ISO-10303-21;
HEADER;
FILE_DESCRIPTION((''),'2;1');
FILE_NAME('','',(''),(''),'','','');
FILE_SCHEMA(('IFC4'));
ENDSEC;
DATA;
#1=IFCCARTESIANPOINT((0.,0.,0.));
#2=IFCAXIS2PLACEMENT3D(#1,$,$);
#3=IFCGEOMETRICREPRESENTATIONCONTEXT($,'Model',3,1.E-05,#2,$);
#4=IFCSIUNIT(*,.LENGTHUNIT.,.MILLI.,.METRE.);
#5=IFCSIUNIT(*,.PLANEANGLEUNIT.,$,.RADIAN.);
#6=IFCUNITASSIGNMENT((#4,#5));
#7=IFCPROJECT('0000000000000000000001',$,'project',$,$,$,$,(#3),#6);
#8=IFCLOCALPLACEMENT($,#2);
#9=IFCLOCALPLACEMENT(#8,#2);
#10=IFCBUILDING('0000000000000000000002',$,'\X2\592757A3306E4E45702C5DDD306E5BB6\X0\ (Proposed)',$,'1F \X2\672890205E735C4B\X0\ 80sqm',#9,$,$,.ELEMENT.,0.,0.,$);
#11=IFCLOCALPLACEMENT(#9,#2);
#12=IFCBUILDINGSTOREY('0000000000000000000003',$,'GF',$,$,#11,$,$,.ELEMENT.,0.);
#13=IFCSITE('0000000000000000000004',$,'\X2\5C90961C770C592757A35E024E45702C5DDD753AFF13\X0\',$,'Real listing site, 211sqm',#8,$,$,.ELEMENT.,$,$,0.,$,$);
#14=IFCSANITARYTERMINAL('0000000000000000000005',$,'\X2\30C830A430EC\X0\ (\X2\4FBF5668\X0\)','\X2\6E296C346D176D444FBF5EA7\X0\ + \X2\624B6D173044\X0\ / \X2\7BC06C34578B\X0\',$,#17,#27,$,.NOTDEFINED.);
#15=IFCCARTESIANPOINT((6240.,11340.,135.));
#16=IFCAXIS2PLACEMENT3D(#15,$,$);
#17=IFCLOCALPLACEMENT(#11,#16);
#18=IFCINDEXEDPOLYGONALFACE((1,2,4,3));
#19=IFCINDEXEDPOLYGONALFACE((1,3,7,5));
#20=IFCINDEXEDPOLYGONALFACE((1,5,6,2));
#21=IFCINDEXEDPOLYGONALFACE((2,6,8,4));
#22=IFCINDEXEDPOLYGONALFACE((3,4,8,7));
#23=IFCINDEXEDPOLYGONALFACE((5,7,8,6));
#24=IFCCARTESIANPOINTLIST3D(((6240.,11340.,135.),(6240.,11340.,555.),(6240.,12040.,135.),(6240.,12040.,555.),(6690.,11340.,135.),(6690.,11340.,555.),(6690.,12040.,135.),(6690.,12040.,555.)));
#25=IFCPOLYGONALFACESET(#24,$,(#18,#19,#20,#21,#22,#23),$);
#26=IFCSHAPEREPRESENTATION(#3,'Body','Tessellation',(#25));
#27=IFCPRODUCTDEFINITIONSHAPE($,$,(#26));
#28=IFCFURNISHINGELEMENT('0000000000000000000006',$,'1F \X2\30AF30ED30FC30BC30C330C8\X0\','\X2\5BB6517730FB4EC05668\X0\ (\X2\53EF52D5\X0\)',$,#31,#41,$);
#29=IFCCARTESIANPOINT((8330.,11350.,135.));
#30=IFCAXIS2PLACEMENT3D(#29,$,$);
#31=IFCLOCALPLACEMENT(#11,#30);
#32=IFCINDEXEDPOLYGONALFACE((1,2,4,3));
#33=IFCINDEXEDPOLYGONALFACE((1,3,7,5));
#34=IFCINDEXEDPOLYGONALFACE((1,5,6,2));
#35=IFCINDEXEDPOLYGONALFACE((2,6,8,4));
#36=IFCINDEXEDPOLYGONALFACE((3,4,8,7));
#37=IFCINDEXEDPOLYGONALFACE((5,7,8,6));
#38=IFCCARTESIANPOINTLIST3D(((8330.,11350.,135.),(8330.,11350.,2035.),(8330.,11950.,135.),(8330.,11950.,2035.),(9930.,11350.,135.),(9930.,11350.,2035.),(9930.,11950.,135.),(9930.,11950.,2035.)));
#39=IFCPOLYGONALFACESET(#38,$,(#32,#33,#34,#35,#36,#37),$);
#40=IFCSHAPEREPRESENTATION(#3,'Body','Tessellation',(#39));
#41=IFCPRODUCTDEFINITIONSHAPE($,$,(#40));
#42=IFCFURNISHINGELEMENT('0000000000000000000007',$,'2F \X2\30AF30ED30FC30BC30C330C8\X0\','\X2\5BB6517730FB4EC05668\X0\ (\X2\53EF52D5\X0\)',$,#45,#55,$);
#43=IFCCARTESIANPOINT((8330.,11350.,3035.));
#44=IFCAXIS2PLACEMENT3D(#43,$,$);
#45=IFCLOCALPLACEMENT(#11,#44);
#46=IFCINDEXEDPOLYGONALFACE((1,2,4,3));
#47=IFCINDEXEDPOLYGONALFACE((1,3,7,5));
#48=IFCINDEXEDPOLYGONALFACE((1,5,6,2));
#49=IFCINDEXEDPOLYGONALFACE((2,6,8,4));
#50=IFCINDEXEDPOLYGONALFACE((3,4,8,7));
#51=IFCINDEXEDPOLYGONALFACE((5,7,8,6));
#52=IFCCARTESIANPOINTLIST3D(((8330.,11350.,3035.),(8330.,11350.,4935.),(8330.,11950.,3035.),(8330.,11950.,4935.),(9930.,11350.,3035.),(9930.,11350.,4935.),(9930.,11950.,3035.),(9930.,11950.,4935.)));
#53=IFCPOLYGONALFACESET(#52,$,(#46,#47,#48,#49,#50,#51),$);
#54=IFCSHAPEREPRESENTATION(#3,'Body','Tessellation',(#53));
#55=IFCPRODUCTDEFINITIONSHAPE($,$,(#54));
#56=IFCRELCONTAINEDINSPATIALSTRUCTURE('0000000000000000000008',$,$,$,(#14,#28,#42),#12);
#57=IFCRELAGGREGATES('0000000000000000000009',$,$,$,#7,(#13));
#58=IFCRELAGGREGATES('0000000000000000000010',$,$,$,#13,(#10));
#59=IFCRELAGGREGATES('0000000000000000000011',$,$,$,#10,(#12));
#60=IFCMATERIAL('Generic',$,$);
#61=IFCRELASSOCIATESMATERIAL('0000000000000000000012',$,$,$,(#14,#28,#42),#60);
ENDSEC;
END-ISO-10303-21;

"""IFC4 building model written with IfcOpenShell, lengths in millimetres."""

from ifc_helpers import new_model, si_unit, frame, frame_2d, origin, place, context, project, spatial, rectangle, extrude, material, element, save


model = new_model("IFC4")

# Units and contexts
model_context = context("Model", 3, precision=1e-05, world=origin())
ifc_project = project(units=[si_unit("LENGTHUNIT", "METRE", prefix="MILLI"), si_unit("PLANEANGLEUNIT", "RADIAN")], contexts=[model_context])

# Site, building, storey
site_placement = place(None, origin())
site = spatial("IfcSite", under=ifc_project, at=site_placement, Name="岐阜県大垣市久瀬川町３", ObjectType="Real listing site, 211sqm", CompositionType="ELEMENT", RefElevation=0.0)
building_placement = place(site_placement, origin())
building = spatial("IfcBuilding", under=site, at=building_placement, Name="大垣の久瀬川の家 (Proposed)", ObjectType="1F 木造平屋 80sqm", CompositionType="ELEMENT", ElevationOfRefHeight=0.0, ElevationOfTerrain=0.0)
storey_placement = place(building_placement, origin())
storey = spatial("IfcBuildingStorey", under=building, at=storey_placement, Name="GF", CompositionType="ELEMENT", Elevation=0.0)

# Sanitary terminal
ifc_material_1 = material(Name="Generic")
sanitary_terminal_1_placement = place(storey_placement, frame((6240.0, 11340.0, 135.0)))
element("IfcSanitaryTerminal", 1, at=sanitary_terminal_1_placement, inside=storey, material=ifc_material_1, Name="トイレ (便器)", Description="温水洗浄便座 + 手洗い / 節水型", PredefinedType="NOTDEFINED", context=model_context, shape_type="SweptSolid", body=[
    extrude(rectangle(XDim=450.0, YDim=700.0, at=frame_2d((225.0, 350.0))), frame((6240.0, 11340.0, 135.0)), (0.0, 0.0, 1.0), 420.0),
])

# Furnishing elements
furnishing_1_placement = place(storey_placement, frame((8330.0, 11350.0, 135.0)))
element("IfcFurnishingElement", 2, at=furnishing_1_placement, inside=storey, material=ifc_material_1, Name="1F クローゼット", Description="家具・什器 (可動)", context=model_context, shape_type="SweptSolid", body=[
    extrude(rectangle(XDim=1600.0, YDim=600.0, at=frame_2d((800.0, 300.0))), frame((8330.0, 11350.0, 135.0)), (0.0, 0.0, 1.0), 1900.0),
])
furnishing_2_placement = place(storey_placement, frame((8330.0, 11350.0, 3035.0)))
element("IfcFurnishingElement", 3, at=furnishing_2_placement, inside=storey, material=ifc_material_1, Name="2F クローゼット", Description="家具・什器 (可動)", context=model_context, shape_type="SweptSolid", body=[
    extrude(rectangle(XDim=1600.0, YDim=600.0, at=frame_2d((800.0, 300.0))), frame((8330.0, 11350.0, 3035.0)), (0.0, 0.0, 1.0), 1900.0),
])

save(model, "model.ifc")
